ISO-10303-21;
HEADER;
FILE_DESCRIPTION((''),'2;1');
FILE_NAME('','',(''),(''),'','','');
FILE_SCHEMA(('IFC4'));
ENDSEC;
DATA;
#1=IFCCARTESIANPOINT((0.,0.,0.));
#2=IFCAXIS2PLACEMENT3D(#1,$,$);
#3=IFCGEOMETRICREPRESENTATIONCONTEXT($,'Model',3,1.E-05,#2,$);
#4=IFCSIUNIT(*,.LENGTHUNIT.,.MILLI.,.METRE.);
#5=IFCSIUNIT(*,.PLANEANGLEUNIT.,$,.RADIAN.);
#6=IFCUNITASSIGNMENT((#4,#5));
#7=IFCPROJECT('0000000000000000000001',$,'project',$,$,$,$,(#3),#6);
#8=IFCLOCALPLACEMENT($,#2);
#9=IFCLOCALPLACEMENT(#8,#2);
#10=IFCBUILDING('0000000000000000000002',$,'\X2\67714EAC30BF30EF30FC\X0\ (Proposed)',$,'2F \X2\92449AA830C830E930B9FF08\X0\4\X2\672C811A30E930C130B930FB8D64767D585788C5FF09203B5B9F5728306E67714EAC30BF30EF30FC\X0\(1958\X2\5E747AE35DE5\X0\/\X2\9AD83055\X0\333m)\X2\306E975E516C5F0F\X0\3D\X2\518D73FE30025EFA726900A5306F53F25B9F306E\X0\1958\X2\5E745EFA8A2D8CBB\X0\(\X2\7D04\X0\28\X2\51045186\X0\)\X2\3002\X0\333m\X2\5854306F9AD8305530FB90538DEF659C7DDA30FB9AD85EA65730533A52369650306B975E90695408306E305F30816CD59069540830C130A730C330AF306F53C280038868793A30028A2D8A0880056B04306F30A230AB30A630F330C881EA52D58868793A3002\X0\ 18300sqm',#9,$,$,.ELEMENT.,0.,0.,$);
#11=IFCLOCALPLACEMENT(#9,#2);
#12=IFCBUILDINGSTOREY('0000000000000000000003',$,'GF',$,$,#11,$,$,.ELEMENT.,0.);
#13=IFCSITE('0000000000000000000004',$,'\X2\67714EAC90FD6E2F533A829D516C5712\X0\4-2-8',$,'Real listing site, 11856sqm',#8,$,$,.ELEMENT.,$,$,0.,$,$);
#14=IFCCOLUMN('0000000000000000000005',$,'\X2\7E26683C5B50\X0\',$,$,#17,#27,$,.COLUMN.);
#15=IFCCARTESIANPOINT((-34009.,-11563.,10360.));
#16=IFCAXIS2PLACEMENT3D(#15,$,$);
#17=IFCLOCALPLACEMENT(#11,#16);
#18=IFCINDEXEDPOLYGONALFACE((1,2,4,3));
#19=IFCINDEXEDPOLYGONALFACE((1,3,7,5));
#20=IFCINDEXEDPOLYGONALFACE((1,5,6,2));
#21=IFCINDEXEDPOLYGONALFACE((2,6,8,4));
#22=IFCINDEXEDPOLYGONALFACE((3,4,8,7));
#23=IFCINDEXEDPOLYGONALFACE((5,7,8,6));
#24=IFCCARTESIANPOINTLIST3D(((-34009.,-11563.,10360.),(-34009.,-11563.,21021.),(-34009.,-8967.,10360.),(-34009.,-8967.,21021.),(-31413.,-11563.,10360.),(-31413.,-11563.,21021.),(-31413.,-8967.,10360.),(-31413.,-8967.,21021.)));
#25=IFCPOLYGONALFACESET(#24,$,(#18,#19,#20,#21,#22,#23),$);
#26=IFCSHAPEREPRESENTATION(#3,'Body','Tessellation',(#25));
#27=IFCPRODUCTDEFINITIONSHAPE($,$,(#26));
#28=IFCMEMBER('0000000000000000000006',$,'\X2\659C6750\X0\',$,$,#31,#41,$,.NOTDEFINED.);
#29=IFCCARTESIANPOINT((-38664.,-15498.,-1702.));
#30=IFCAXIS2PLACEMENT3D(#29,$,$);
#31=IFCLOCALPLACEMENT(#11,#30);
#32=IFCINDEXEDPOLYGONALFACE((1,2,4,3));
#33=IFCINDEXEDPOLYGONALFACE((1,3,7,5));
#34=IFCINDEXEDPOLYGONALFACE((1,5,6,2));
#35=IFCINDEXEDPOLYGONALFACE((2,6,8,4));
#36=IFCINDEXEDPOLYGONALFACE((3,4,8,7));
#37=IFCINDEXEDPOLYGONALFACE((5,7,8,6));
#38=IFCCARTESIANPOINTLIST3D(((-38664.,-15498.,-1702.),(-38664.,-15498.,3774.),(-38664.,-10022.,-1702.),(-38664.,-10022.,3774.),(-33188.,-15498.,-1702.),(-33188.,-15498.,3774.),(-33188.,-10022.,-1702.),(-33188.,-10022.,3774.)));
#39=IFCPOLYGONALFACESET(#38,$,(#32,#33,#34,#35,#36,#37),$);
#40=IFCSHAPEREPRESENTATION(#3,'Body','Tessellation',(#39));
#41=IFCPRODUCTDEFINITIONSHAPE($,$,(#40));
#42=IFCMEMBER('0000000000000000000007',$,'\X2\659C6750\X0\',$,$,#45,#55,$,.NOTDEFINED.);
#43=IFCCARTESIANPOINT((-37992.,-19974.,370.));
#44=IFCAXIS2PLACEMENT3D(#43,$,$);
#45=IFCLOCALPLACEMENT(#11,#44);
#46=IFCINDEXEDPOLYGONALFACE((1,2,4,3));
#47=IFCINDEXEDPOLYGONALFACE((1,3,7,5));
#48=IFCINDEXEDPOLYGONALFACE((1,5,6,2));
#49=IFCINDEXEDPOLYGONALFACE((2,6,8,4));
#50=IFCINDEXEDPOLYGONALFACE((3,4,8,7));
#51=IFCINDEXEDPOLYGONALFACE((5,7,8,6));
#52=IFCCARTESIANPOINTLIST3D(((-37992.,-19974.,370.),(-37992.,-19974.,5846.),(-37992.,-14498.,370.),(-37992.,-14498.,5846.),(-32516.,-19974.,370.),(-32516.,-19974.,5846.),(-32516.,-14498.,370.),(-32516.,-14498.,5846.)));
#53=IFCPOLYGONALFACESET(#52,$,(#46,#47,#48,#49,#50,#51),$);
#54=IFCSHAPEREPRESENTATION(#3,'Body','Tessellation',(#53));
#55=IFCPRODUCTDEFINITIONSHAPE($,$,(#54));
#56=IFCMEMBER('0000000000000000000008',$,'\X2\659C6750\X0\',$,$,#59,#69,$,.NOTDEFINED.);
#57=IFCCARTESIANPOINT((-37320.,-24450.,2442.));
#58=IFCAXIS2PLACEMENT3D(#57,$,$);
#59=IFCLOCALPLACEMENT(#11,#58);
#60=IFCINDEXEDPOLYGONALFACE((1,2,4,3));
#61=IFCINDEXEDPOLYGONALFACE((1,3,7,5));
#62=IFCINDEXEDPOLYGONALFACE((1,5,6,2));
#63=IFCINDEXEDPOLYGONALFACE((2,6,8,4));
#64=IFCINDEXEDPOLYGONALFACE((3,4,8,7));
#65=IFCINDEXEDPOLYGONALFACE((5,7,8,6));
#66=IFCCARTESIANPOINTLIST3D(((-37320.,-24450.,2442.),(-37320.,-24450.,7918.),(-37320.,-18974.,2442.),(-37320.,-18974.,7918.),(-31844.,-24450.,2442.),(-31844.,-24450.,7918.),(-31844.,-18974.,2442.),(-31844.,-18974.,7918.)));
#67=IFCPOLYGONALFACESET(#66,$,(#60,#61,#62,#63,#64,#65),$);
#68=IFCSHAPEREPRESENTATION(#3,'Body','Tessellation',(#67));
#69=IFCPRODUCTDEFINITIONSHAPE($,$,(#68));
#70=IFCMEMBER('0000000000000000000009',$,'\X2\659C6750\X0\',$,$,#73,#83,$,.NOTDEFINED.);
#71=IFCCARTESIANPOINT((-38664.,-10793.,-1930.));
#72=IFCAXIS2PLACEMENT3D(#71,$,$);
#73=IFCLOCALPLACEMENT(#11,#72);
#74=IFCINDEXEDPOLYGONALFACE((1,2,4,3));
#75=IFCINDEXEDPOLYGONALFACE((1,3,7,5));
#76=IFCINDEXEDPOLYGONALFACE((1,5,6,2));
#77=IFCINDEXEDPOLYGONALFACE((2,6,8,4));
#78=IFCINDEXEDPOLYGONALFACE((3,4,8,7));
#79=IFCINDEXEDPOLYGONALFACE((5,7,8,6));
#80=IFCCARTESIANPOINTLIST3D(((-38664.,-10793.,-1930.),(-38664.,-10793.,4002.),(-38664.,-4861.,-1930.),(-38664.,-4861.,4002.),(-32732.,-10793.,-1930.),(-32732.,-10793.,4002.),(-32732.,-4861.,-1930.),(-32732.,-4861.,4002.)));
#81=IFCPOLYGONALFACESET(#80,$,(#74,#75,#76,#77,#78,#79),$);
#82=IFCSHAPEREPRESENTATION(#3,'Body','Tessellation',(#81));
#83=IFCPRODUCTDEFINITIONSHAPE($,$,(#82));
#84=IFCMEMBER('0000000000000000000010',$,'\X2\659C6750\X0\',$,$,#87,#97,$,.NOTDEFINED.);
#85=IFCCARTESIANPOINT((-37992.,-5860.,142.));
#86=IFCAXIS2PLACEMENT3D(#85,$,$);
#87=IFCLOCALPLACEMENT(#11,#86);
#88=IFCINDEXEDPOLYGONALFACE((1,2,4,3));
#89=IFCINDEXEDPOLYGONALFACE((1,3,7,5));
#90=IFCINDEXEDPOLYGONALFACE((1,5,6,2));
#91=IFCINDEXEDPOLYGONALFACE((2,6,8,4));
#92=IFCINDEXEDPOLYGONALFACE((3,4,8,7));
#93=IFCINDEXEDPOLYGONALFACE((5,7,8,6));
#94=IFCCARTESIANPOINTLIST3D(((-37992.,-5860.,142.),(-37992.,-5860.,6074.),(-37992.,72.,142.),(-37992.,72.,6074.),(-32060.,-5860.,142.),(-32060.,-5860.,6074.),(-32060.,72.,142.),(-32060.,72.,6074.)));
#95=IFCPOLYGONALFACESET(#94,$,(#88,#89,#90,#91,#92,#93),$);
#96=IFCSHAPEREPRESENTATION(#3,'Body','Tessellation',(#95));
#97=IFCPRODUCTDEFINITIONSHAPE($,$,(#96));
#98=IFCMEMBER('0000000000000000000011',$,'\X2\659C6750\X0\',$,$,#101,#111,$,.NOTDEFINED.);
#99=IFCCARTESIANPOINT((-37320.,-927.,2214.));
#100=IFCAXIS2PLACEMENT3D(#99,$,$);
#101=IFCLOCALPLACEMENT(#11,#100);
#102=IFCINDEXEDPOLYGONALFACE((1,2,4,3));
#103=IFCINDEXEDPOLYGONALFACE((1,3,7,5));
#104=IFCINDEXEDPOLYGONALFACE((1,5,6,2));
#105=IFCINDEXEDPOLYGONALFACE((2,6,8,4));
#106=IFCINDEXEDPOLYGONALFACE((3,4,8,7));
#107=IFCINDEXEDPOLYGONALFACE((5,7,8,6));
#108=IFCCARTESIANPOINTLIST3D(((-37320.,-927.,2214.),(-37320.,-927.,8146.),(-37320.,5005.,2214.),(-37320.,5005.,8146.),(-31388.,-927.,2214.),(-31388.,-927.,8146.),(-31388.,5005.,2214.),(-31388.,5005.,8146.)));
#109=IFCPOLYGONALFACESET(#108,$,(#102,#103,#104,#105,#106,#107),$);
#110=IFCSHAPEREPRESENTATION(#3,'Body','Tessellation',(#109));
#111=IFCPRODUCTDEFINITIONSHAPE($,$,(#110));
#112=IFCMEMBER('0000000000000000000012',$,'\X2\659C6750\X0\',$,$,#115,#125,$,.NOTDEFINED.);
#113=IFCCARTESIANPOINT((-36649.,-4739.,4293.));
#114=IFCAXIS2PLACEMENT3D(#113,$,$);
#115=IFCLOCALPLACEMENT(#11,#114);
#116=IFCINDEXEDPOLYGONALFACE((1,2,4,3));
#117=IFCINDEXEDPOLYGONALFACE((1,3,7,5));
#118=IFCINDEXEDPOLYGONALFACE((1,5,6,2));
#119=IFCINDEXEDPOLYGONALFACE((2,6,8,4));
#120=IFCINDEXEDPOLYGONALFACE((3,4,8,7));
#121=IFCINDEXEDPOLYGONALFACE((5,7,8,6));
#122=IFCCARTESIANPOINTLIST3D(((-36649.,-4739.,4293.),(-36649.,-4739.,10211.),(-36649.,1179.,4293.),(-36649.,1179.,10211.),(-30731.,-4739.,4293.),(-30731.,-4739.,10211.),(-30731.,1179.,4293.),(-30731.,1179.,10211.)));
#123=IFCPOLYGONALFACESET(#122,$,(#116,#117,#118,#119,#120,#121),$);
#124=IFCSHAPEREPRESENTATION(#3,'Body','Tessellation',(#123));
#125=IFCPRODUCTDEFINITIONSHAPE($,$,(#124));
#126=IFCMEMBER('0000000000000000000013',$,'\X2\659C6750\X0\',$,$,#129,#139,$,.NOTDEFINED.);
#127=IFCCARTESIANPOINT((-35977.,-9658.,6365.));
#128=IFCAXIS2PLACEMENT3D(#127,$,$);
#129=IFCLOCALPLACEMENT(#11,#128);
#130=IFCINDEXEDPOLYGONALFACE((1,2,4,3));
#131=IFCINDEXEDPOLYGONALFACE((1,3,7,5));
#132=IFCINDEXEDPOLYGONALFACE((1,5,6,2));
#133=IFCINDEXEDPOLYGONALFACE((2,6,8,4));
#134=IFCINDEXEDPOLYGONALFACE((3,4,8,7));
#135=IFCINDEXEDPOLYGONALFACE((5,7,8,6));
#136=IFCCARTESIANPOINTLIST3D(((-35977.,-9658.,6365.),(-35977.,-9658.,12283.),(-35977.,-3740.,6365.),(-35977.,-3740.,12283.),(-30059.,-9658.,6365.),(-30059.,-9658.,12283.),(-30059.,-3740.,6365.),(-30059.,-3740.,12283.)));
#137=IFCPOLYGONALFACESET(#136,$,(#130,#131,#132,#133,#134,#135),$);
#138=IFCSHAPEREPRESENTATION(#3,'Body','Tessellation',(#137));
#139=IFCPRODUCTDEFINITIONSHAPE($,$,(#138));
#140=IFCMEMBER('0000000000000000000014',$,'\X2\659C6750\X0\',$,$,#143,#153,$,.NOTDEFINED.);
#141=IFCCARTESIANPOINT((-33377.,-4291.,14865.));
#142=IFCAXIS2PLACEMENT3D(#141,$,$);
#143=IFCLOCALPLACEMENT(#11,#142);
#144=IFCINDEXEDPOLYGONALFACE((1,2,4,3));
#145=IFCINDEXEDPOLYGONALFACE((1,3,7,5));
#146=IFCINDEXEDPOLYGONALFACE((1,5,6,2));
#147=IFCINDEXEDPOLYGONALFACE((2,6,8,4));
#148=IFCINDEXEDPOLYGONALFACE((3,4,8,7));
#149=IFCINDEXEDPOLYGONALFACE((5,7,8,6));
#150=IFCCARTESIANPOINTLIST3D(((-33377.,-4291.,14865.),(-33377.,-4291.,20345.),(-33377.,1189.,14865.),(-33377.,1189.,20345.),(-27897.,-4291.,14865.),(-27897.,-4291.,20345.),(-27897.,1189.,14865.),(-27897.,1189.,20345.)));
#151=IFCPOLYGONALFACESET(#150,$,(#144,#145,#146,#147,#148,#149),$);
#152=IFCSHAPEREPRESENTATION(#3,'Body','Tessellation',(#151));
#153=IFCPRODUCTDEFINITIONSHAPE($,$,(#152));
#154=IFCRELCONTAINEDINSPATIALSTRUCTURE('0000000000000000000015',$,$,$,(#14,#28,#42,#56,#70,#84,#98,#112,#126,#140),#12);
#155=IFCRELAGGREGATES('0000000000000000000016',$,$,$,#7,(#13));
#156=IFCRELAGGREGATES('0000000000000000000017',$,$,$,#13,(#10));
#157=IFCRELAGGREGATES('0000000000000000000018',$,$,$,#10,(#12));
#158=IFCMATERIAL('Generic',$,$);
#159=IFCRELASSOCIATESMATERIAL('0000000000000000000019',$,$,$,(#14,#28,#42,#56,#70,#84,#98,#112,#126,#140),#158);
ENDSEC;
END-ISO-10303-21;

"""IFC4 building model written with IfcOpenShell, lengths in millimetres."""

from ifc_helpers import new_model, si_unit, frame, frame_2d, origin, place, context, project, spatial, rectangle, extrude, material, element, save


model = new_model("IFC4")

# Units and contexts
model_context = context("Model", 3, precision=1e-05, world=origin())
ifc_project = project(units=[si_unit("LENGTHUNIT", "METRE", prefix="MILLI"), si_unit("PLANEANGLEUNIT", "RADIAN")], contexts=[model_context])

# Site, building, storey
site_placement = place(None, origin())
site = spatial("IfcSite", under=ifc_project, at=site_placement, Name="東京都港区芝公園4-2-8", ObjectType="Real listing site, 11856sqm", CompositionType="ELEMENT", RefElevation=0.0)
building_placement = place(site_placement, origin())
building = spatial("IfcBuilding", under=site, at=building_placement, Name="東京タワー (Proposed)", ObjectType="2F 鉄骨トラス（4本脚ラチス・赤白塗装）※実在の東京タワー(1958年竣工/高さ333m)の非公式3D再現。建物¥は史実の1958年建設費(約28億円)。333m塔は高さ・道路斜線・高度地区制限に非適合のため法適合チェックは参考表示。設計者欄はアカウント自動表示。 18300sqm", CompositionType="ELEMENT", ElevationOfRefHeight=0.0, ElevationOfTerrain=0.0)
storey_placement = place(building_placement, origin())
storey = spatial("IfcBuildingStorey", under=building, at=storey_placement, Name="GF", CompositionType="ELEMENT", Elevation=0.0)

# Column
ifc_material = material(Name="Generic")
column_1_placement = place(storey_placement, frame((-34009.0, -11563.0, 10360.0)))
element("IfcColumn", 1, at=column_1_placement, inside=storey, material=ifc_material, Name="縦格子", PredefinedType="COLUMN", context=model_context, shape_type="SweptSolid", body=[
    extrude(rectangle(XDim=2596.0, YDim=2596.0, at=frame_2d((1298.0, 1298.0))), frame((-34009.0, -11563.0, 10360.0)), (0.0, 0.0, 1.0), 10661.0),
])

# Members
member_1_placement = place(storey_placement, frame((-38664.0, -15498.0, -1702.0)))
element("IfcMember", 2, at=member_1_placement, inside=storey, material=ifc_material, Name="斜材", PredefinedType="NOTDEFINED", context=model_context, shape_type="SweptSolid", body=[
    extrude(rectangle(XDim=5476.0, YDim=5476.0, at=frame_2d((2738.0, 2738.0))), frame((-38664.0, -15498.0, -1702.0)), (0.0, 0.0, 1.0), 5476.0),
])
member_2_placement = place(storey_placement, frame((-37992.0, -19974.0, 370.0)))
element("IfcMember", 3, at=member_2_placement, inside=storey, material=ifc_material, Name="斜材", PredefinedType="NOTDEFINED", context=model_context, shape_type="SweptSolid", body=[
    extrude(rectangle(XDim=5476.0, YDim=5476.0, at=frame_2d((2738.0, 2738.0))), frame((-37992.0, -19974.0, 370.0)), (0.0, 0.0, 1.0), 5476.0),
])
member_3_placement = place(storey_placement, frame((-37320.0, -24450.0, 2442.0)))
element("IfcMember", 4, at=member_3_placement, inside=storey, material=ifc_material, Name="斜材", PredefinedType="NOTDEFINED", context=model_context, shape_type="SweptSolid", body=[
    extrude(rectangle(XDim=5476.0, YDim=5476.0, at=frame_2d((2738.0, 2738.0))), frame((-37320.0, -24450.0, 2442.0)), (0.0, 0.0, 1.0), 5476.0),
])
member_4_placement = place(storey_placement, frame((-38664.0, -10793.0, -1930.0)))
element("IfcMember", 5, at=member_4_placement, inside=storey, material=ifc_material, Name="斜材", PredefinedType="NOTDEFINED", context=model_context, shape_type="SweptSolid", body=[
    extrude(rectangle(XDim=5932.0, YDim=5932.0, at=frame_2d((2966.0, 2966.0))), frame((-38664.0, -10793.0, -1930.0)), (0.0, 0.0, 1.0), 5932.0),
])
member_5_placement = place(storey_placement, frame((-37992.0, -5860.0, 142.0)))
element("IfcMember", 6, at=member_5_placement, inside=storey, material=ifc_material, Name="斜材", PredefinedType="NOTDEFINED", context=model_context, shape_type="SweptSolid", body=[
    extrude(rectangle(XDim=5932.0, YDim=5932.0, at=frame_2d((2966.0, 2966.0))), frame((-37992.0, -5860.0, 142.0)), (0.0, 0.0, 1.0), 5932.0),
])
member_6_placement = place(storey_placement, frame((-37320.0, -927.0, 2214.0)))
element("IfcMember", 7, at=member_6_placement, inside=storey, material=ifc_material, Name="斜材", PredefinedType="NOTDEFINED", context=model_context, shape_type="SweptSolid", body=[
    extrude(rectangle(XDim=5932.0, YDim=5932.0, at=frame_2d((2966.0, 2966.0))), frame((-37320.0, -927.0, 2214.0)), (0.0, 0.0, 1.0), 5932.0),
])
member_7_placement = place(storey_placement, frame((-36649.0, -4739.0, 4293.0)))
element("IfcMember", 8, at=member_7_placement, inside=storey, material=ifc_material, Name="斜材", PredefinedType="NOTDEFINED", context=model_context, shape_type="SweptSolid", body=[
    extrude(rectangle(XDim=5918.0, YDim=5918.0, at=frame_2d((2959.0, 2959.0))), frame((-36649.0, -4739.0, 4293.0)), (0.0, 0.0, 1.0), 5918.0),
])
member_8_placement = place(storey_placement, frame((-35977.0, -9658.0, 6365.0)))
element("IfcMember", 9, at=member_8_placement, inside=storey, material=ifc_material, Name="斜材", PredefinedType="NOTDEFINED", context=model_context, shape_type="SweptSolid", body=[
    extrude(rectangle(XDim=5918.0, YDim=5918.0, at=frame_2d((2959.0, 2959.0))), frame((-35977.0, -9658.0, 6365.0)), (0.0, 0.0, 1.0), 5918.0),
])
member_9_placement = place(storey_placement, frame((-33377.0, -4291.0, 14865.0)))
element("IfcMember", 10, at=member_9_placement, inside=storey, material=ifc_material, Name="斜材", PredefinedType="NOTDEFINED", context=model_context, shape_type="SweptSolid", body=[
    extrude(rectangle(XDim=5480.0, YDim=5480.0, at=frame_2d((2740.0, 2740.0))), frame((-33377.0, -4291.0, 14865.0)), (0.0, 0.0, 1.0), 5480.0),
])

save(model, "model.ifc")
